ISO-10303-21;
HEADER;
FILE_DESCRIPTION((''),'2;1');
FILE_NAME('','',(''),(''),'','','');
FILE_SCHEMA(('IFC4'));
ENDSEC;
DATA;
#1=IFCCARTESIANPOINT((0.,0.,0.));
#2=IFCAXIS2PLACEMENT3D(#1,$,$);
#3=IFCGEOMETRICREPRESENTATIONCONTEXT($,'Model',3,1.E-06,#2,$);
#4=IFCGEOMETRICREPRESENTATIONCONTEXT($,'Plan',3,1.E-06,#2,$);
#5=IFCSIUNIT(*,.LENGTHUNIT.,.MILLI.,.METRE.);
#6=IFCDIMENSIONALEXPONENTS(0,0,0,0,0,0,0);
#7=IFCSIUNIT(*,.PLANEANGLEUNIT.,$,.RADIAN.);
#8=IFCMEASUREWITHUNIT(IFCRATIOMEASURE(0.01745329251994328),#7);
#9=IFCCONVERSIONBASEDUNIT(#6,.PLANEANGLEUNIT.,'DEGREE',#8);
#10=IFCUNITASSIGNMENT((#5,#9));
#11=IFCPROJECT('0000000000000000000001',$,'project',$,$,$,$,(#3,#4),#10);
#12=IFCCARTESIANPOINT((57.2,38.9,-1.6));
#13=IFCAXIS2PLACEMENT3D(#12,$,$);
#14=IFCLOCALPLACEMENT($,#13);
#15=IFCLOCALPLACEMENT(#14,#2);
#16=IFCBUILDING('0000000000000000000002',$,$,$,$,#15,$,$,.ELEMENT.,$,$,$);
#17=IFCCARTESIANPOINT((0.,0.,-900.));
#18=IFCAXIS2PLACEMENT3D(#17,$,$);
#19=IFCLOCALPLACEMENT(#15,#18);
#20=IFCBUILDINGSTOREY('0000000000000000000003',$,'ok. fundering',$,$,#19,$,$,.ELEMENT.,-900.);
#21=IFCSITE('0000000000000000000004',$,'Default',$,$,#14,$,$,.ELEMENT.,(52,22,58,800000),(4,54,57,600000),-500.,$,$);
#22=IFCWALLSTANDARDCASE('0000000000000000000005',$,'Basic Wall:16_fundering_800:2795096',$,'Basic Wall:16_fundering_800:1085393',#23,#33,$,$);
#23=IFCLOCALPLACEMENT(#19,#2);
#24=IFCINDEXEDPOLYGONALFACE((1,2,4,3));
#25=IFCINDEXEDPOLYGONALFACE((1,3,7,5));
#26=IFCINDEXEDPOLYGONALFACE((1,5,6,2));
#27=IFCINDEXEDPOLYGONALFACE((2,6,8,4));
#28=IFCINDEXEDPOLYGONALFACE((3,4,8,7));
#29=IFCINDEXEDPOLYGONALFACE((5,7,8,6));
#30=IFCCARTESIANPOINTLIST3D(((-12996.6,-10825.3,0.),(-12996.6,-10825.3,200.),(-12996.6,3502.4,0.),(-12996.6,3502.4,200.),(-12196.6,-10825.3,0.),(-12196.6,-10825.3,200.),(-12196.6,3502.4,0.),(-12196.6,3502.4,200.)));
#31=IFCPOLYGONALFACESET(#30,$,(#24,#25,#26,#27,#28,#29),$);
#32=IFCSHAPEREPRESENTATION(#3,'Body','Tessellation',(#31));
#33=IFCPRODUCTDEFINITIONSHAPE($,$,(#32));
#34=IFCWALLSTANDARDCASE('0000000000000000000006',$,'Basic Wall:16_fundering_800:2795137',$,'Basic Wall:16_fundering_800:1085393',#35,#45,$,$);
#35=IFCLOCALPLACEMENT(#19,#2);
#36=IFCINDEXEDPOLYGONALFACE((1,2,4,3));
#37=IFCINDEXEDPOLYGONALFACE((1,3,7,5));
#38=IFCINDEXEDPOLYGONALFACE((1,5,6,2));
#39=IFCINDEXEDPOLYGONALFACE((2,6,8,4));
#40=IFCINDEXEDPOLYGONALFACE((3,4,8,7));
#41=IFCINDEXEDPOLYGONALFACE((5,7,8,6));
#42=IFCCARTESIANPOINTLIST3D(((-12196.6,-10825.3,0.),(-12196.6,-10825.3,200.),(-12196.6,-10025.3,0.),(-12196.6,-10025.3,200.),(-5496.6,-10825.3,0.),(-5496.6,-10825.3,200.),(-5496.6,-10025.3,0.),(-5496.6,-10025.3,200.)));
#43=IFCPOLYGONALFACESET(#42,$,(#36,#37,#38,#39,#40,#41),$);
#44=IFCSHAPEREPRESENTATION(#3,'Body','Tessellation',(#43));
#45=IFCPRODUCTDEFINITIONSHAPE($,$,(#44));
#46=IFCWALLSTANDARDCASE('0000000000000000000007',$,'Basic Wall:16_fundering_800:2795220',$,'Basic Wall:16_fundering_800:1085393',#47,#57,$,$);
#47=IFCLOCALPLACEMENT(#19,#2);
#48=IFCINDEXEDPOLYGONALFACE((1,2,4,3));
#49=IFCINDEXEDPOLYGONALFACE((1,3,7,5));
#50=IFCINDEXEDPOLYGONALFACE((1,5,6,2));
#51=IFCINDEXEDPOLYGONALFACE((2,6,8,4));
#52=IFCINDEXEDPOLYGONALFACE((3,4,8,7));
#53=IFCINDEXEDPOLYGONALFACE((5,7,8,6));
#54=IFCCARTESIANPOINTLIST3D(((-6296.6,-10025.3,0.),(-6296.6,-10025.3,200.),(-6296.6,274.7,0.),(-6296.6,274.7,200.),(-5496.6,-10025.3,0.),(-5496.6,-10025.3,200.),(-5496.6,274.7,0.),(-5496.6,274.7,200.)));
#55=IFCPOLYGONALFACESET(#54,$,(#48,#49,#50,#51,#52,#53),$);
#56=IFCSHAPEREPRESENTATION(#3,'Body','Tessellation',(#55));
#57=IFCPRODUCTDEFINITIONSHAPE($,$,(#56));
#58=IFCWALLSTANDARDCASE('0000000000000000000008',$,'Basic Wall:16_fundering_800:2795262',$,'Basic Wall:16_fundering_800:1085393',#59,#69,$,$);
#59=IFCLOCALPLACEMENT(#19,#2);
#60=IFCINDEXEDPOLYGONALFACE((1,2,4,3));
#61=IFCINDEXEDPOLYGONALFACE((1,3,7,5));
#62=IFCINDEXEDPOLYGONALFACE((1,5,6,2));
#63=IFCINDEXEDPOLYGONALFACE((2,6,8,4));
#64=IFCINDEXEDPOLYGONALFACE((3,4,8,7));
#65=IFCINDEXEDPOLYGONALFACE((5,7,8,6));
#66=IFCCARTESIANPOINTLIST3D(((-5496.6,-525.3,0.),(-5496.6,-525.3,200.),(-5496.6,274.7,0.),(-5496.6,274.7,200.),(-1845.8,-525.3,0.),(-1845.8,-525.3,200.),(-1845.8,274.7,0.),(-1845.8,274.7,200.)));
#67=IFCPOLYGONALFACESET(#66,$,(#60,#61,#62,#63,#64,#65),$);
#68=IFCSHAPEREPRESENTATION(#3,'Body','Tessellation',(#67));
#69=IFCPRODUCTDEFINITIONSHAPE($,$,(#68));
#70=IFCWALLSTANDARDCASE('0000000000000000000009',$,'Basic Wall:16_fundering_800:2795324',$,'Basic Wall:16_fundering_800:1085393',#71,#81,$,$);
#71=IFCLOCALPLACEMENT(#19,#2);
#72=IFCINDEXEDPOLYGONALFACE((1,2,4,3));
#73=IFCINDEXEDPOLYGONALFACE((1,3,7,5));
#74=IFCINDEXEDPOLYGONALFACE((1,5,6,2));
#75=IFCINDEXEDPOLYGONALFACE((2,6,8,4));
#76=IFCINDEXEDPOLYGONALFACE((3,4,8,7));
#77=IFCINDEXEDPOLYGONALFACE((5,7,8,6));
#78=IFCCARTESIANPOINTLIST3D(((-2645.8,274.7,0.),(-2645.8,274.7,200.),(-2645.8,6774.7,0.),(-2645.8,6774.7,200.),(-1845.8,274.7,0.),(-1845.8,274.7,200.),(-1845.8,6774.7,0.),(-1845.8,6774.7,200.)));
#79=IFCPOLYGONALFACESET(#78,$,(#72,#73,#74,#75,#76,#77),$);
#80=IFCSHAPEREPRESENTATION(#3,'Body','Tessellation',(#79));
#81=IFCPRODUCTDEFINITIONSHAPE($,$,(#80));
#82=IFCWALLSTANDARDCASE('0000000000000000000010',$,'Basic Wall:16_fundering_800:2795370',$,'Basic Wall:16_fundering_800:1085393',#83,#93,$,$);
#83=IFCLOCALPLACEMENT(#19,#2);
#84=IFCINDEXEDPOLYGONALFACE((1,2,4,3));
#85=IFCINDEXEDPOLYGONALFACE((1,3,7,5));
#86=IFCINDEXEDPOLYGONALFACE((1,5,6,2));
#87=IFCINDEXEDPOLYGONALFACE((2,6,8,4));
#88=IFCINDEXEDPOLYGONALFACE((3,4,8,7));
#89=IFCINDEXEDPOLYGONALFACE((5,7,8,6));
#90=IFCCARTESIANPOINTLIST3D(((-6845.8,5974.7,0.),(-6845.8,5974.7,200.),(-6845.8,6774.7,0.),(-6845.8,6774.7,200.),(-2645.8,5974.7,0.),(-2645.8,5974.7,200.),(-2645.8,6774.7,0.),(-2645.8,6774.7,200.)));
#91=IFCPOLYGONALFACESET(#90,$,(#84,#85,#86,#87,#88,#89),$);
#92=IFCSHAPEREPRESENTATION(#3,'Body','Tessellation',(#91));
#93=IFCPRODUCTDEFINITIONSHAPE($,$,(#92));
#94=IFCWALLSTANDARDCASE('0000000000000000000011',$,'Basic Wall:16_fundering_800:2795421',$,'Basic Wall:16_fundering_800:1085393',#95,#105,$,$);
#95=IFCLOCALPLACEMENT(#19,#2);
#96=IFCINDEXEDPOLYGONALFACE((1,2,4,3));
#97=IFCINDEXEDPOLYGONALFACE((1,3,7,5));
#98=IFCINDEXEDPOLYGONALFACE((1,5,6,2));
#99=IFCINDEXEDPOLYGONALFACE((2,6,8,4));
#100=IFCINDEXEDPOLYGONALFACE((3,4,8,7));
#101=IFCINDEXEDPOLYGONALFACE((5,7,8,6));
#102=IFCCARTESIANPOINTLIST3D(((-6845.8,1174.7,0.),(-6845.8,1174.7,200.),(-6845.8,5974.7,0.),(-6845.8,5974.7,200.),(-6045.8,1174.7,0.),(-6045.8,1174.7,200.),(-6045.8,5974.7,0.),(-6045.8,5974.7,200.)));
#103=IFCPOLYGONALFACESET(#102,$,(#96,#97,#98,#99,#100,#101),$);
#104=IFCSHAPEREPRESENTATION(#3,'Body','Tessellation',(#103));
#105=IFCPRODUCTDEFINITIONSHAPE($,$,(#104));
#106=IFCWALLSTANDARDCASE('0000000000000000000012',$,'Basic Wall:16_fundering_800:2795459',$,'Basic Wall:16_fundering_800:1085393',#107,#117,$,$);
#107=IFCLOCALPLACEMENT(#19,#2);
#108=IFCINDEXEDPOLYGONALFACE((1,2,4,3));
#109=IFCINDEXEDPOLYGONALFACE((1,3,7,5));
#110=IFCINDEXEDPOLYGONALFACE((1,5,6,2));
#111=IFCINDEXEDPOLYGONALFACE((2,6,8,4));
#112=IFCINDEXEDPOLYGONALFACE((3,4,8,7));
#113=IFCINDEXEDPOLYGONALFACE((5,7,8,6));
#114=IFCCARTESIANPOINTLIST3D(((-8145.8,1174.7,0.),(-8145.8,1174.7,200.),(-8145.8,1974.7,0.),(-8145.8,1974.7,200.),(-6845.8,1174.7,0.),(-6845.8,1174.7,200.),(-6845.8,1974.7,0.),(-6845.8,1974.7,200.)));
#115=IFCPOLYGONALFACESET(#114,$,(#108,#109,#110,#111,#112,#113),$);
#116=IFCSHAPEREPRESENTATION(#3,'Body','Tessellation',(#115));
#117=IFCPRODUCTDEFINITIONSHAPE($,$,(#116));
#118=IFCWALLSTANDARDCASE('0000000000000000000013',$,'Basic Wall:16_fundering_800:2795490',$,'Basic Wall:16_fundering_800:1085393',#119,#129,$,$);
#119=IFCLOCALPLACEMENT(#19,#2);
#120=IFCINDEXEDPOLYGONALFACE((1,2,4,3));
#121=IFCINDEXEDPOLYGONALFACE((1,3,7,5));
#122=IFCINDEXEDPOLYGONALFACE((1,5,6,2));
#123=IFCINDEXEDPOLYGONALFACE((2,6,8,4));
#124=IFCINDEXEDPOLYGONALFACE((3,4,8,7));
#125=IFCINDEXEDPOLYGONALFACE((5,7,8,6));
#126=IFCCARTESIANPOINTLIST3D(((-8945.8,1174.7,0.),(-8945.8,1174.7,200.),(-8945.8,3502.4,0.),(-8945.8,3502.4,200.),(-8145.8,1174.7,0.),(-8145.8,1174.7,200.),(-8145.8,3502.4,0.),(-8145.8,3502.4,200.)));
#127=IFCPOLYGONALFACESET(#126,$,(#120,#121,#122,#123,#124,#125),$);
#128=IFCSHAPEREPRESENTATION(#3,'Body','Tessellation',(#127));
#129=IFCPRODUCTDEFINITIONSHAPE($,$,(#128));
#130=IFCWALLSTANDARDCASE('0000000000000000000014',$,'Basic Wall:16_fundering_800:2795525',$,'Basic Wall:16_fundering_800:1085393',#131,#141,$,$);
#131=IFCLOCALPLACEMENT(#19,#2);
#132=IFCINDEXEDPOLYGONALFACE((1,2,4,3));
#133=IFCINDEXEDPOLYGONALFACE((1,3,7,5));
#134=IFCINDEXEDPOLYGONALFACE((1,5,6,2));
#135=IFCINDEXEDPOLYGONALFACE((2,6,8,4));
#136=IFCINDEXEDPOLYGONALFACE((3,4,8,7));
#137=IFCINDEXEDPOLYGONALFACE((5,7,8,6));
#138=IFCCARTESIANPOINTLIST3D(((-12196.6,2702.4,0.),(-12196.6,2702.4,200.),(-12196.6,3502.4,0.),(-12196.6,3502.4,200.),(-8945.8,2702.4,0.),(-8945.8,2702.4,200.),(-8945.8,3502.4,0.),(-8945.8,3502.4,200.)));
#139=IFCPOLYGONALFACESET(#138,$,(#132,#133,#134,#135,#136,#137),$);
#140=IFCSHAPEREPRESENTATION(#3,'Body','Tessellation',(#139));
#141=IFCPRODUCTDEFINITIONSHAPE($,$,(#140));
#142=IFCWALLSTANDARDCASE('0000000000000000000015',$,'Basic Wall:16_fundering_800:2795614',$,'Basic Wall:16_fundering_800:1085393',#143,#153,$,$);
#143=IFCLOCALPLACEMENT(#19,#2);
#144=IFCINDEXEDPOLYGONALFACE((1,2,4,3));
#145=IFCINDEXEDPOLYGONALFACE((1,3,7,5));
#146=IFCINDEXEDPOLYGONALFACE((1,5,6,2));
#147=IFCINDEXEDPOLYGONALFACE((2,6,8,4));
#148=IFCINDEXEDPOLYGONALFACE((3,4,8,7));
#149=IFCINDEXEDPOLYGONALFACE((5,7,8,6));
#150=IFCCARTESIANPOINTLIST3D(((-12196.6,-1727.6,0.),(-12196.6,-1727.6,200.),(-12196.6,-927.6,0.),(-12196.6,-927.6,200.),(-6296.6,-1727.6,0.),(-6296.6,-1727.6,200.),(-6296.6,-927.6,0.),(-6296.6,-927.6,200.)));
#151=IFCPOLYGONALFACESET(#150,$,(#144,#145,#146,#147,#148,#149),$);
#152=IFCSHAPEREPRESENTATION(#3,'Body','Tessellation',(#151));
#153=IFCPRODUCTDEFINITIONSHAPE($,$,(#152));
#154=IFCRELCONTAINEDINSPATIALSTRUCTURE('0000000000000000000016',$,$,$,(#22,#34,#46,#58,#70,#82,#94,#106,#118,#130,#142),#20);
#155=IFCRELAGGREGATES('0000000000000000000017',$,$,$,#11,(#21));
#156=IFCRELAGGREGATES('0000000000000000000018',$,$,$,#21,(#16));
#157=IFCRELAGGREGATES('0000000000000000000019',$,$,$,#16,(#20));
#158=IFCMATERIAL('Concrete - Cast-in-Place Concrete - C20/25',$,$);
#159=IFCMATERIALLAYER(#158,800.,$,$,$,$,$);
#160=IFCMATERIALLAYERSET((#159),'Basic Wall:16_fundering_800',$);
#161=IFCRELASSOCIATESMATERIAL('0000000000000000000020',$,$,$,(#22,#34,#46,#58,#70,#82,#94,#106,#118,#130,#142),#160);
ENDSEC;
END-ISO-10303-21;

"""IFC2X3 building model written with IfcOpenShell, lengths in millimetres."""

from ifc_helpers import new_model, entity, si_unit, converted_unit, frame, frame_2d, origin, place, context, project, spatial, rectangle, extrude, material, layer, layer_set, layer_usage, element, save


model = new_model("IFC2X3")

# Units and contexts
model_context = context("Model", 3, precision=1e-06, world=origin())
plan_context = context("Plan", 3, precision=1e-06, world=origin())
ifc_project = project(units=[si_unit("LENGTHUNIT", "METRE", prefix="MILLI"), converted_unit("PLANEANGLEUNIT", "DEGREE", entity("IfcRatioMeasure", 0.01745329251994328), si_unit("PLANEANGLEUNIT", "RADIAN"), dimensions=[0, 0, 0, 0, 0, 0, 0])], contexts=[model_context, plan_context])

# Site, building, storey
site_placement = place(None, frame((57.2, 38.9, -1.6)))
site = spatial("IfcSite", under=ifc_project, at=site_placement, Name="Default", CompositionType="ELEMENT", RefLatitude=(52, 22, 58, 800000), RefLongitude=(4, 54, 57, 600000), RefElevation=-500.0)
building_placement = place(site_placement, origin())
building = spatial("IfcBuilding", under=site, at=building_placement, CompositionType="ELEMENT")
storey_placement = place(building_placement, frame((0.0, 0.0, -900.0)))
storey = spatial("IfcBuildingStorey", under=building, at=storey_placement, Name="ok. fundering", CompositionType="ELEMENT", Elevation=-900.0)

# Walls
ifc_material = material(Name="Concrete - Cast-in-Place Concrete - C20/25")
ifc_layer = layer(ifc_material, 800.0)
ifc_layer_set = layer_set([ifc_layer], Name="Basic Wall:16_fundering_800")
ifc_layer_usage_1 = layer_usage(ifc_layer_set, "AXIS2", "NEGATIVE", 400.0)
wall_1_placement = place(storey_placement, frame((-12596.6, 3502.4, 0.0), z_axis=(0.0, 0.0, 1.0), x_axis=(0.0, -1.0, 0.0)))
element("IfcWallStandardCase", 1, at=wall_1_placement, inside=storey, material=ifc_layer_usage_1, Name="Basic Wall:16_fundering_800:2795096", ObjectType="Basic Wall:16_fundering_800:1085393", context=model_context, shape_type="SweptSolid", body=[
    extrude(rectangle(XDim=14327.6, YDim=800.0, at=frame_2d((7163.8, 0.0), x_axis=(-1.0, 0.0))), origin(), (0.0, 0.0, 1.0), 200.0),
])
ifc_layer_usage_2 = layer_usage(ifc_layer_set, "AXIS2", "NEGATIVE", 400.0)
wall_2_placement = place(storey_placement, frame((-12196.6, -10425.3, 0.0)))
element("IfcWallStandardCase", 2, at=wall_2_placement, inside=storey, material=ifc_layer_usage_2, Name="Basic Wall:16_fundering_800:2795137", ObjectType="Basic Wall:16_fundering_800:1085393", context=model_context, shape_type="SweptSolid", body=[
    extrude(rectangle(XDim=6700.0, YDim=800.0, at=frame_2d((3350.0, 0.0), x_axis=(-1.0, 0.0))), origin(), (0.0, 0.0, 1.0), 200.0),
])
ifc_layer_usage_3 = layer_usage(ifc_layer_set, "AXIS2", "NEGATIVE", 400.0)
wall_3_placement = place(storey_placement, frame((-5896.6, -10025.3, 0.0), z_axis=(0.0, 0.0, 1.0), x_axis=(0.0, 1.0, 0.0)))
element("IfcWallStandardCase", 3, at=wall_3_placement, inside=storey, material=ifc_layer_usage_3, Name="Basic Wall:16_fundering_800:2795220", ObjectType="Basic Wall:16_fundering_800:1085393", context=model_context, shape_type="SweptSolid", body=[
    extrude(rectangle(XDim=10300.0, YDim=800.0, at=frame_2d((5150.0, 0.0), x_axis=(-1.0, 0.0))), origin(), (0.0, 0.0, 1.0), 200.0),
])
ifc_layer_usage_4 = layer_usage(ifc_layer_set, "AXIS2", "NEGATIVE", 400.0)
wall_4_placement = place(storey_placement, frame((-5496.6, -125.3, 0.0)))
element("IfcWallStandardCase", 4, at=wall_4_placement, inside=storey, material=ifc_layer_usage_4, Name="Basic Wall:16_fundering_800:2795262", ObjectType="Basic Wall:16_fundering_800:1085393", context=model_context, shape_type="SweptSolid", body=[
    extrude(rectangle(XDim=3650.8, YDim=800.0, at=frame_2d((1825.4, 0.0), x_axis=(-1.0, 0.0))), origin(), (0.0, 0.0, 1.0), 200.0),
])
ifc_layer_usage_5 = layer_usage(ifc_layer_set, "AXIS2", "NEGATIVE", 400.0)
wall_5_placement = place(storey_placement, frame((-2245.8, 274.7, 0.0), z_axis=(0.0, 0.0, 1.0), x_axis=(0.0, 1.0, 0.0)))
element("IfcWallStandardCase", 5, at=wall_5_placement, inside=storey, material=ifc_layer_usage_5, Name="Basic Wall:16_fundering_800:2795324", ObjectType="Basic Wall:16_fundering_800:1085393", context=model_context, shape_type="SweptSolid", body=[
    extrude(rectangle(XDim=6500.0, YDim=800.0, at=frame_2d((3250.0, 0.0), x_axis=(-1.0, 0.0))), origin(), (0.0, 0.0, 1.0), 200.0),
])
ifc_layer_usage_6 = layer_usage(ifc_layer_set, "AXIS2", "NEGATIVE", 400.0)
wall_6_placement = place(storey_placement, frame((-2645.8, 6374.7, 0.0), z_axis=(0.0, 0.0, 1.0), x_axis=(-1.0, 0.0, 0.0)))
element("IfcWallStandardCase", 6, at=wall_6_placement, inside=storey, material=ifc_layer_usage_6, Name="Basic Wall:16_fundering_800:2795370", ObjectType="Basic Wall:16_fundering_800:1085393", context=model_context, shape_type="SweptSolid", body=[
    extrude(rectangle(XDim=4200.0, YDim=800.0, at=frame_2d((2100.0, 0.0), x_axis=(-1.0, 0.0))), origin(), (0.0, 0.0, 1.0), 200.0),
])
ifc_layer_usage_7 = layer_usage(ifc_layer_set, "AXIS2", "NEGATIVE", 400.0)
wall_7_placement = place(storey_placement, frame((-6445.8, 5974.7, 0.0), z_axis=(0.0, 0.0, 1.0), x_axis=(0.0, -1.0, 0.0)))
element("IfcWallStandardCase", 7, at=wall_7_placement, inside=storey, material=ifc_layer_usage_7, Name="Basic Wall:16_fundering_800:2795421", ObjectType="Basic Wall:16_fundering_800:1085393", context=model_context, shape_type="SweptSolid", body=[
    extrude(rectangle(XDim=4800.0, YDim=800.0, at=frame_2d((2400.0, 0.0), x_axis=(-1.0, 0.0))), origin(), (0.0, 0.0, 1.0), 200.0),
])
ifc_layer_usage_8 = layer_usage(ifc_layer_set, "AXIS2", "NEGATIVE", 400.0)
wall_8_placement = place(storey_placement, frame((-6845.8, 1574.7, 0.0), z_axis=(0.0, 0.0, 1.0), x_axis=(-1.0, 0.0, 0.0)))
element("IfcWallStandardCase", 8, at=wall_8_placement, inside=storey, material=ifc_layer_usage_8, Name="Basic Wall:16_fundering_800:2795459", ObjectType="Basic Wall:16_fundering_800:1085393", context=model_context, shape_type="SweptSolid", body=[
    extrude(rectangle(XDim=1300.0, YDim=800.0, at=frame_2d((650.0, 0.0), x_axis=(-1.0, 0.0))), origin(), (0.0, 0.0, 1.0), 200.0),
])
ifc_layer_usage_9 = layer_usage(ifc_layer_set, "AXIS2", "NEGATIVE", 400.0)
wall_9_placement = place(storey_placement, frame((-8545.8, 1174.7, 0.0), z_axis=(0.0, 0.0, 1.0), x_axis=(0.0, 1.0, 0.0)))
element("IfcWallStandardCase", 9, at=wall_9_placement, inside=storey, material=ifc_layer_usage_9, Name="Basic Wall:16_fundering_800:2795490", ObjectType="Basic Wall:16_fundering_800:1085393", context=model_context, shape_type="SweptSolid", body=[
    extrude(rectangle(XDim=2327.6, YDim=800.0, at=frame_2d((1163.8, 0.0), x_axis=(-1.0, 0.0))), origin(), (0.0, 0.0, 1.0), 200.0),
])
ifc_layer_usage_10 = layer_usage(ifc_layer_set, "AXIS2", "NEGATIVE", 400.0)
wall_10_placement = place(storey_placement, frame((-8945.8, 3102.4, 0.0), z_axis=(0.0, 0.0, 1.0), x_axis=(-1.0, 0.0, 0.0)))
element("IfcWallStandardCase", 10, at=wall_10_placement, inside=storey, material=ifc_layer_usage_10, Name="Basic Wall:16_fundering_800:2795525", ObjectType="Basic Wall:16_fundering_800:1085393", context=model_context, shape_type="SweptSolid", body=[
    extrude(rectangle(XDim=3250.8, YDim=800.0, at=frame_2d((1625.4, 0.0), x_axis=(-1.0, 0.0))), origin(), (0.0, 0.0, 1.0), 200.0),
])
ifc_layer_usage_11 = layer_usage(ifc_layer_set, "AXIS2", "NEGATIVE", 400.0)
wall_11_placement = place(storey_placement, frame((-6296.6, -1327.6, 0.0), z_axis=(0.0, 0.0, 1.0), x_axis=(-1.0, 0.0, 0.0)))
element("IfcWallStandardCase", 11, at=wall_11_placement, inside=storey, material=ifc_layer_usage_11, Name="Basic Wall:16_fundering_800:2795614", ObjectType="Basic Wall:16_fundering_800:1085393", context=model_context, shape_type="SweptSolid", body=[
    extrude(rectangle(XDim=5900.0, YDim=800.0, at=frame_2d((2950.0, 0.0), x_axis=(-1.0, 0.0))), origin(), (0.0, 0.0, 1.0), 200.0),
])

save(model, "model.ifc")
